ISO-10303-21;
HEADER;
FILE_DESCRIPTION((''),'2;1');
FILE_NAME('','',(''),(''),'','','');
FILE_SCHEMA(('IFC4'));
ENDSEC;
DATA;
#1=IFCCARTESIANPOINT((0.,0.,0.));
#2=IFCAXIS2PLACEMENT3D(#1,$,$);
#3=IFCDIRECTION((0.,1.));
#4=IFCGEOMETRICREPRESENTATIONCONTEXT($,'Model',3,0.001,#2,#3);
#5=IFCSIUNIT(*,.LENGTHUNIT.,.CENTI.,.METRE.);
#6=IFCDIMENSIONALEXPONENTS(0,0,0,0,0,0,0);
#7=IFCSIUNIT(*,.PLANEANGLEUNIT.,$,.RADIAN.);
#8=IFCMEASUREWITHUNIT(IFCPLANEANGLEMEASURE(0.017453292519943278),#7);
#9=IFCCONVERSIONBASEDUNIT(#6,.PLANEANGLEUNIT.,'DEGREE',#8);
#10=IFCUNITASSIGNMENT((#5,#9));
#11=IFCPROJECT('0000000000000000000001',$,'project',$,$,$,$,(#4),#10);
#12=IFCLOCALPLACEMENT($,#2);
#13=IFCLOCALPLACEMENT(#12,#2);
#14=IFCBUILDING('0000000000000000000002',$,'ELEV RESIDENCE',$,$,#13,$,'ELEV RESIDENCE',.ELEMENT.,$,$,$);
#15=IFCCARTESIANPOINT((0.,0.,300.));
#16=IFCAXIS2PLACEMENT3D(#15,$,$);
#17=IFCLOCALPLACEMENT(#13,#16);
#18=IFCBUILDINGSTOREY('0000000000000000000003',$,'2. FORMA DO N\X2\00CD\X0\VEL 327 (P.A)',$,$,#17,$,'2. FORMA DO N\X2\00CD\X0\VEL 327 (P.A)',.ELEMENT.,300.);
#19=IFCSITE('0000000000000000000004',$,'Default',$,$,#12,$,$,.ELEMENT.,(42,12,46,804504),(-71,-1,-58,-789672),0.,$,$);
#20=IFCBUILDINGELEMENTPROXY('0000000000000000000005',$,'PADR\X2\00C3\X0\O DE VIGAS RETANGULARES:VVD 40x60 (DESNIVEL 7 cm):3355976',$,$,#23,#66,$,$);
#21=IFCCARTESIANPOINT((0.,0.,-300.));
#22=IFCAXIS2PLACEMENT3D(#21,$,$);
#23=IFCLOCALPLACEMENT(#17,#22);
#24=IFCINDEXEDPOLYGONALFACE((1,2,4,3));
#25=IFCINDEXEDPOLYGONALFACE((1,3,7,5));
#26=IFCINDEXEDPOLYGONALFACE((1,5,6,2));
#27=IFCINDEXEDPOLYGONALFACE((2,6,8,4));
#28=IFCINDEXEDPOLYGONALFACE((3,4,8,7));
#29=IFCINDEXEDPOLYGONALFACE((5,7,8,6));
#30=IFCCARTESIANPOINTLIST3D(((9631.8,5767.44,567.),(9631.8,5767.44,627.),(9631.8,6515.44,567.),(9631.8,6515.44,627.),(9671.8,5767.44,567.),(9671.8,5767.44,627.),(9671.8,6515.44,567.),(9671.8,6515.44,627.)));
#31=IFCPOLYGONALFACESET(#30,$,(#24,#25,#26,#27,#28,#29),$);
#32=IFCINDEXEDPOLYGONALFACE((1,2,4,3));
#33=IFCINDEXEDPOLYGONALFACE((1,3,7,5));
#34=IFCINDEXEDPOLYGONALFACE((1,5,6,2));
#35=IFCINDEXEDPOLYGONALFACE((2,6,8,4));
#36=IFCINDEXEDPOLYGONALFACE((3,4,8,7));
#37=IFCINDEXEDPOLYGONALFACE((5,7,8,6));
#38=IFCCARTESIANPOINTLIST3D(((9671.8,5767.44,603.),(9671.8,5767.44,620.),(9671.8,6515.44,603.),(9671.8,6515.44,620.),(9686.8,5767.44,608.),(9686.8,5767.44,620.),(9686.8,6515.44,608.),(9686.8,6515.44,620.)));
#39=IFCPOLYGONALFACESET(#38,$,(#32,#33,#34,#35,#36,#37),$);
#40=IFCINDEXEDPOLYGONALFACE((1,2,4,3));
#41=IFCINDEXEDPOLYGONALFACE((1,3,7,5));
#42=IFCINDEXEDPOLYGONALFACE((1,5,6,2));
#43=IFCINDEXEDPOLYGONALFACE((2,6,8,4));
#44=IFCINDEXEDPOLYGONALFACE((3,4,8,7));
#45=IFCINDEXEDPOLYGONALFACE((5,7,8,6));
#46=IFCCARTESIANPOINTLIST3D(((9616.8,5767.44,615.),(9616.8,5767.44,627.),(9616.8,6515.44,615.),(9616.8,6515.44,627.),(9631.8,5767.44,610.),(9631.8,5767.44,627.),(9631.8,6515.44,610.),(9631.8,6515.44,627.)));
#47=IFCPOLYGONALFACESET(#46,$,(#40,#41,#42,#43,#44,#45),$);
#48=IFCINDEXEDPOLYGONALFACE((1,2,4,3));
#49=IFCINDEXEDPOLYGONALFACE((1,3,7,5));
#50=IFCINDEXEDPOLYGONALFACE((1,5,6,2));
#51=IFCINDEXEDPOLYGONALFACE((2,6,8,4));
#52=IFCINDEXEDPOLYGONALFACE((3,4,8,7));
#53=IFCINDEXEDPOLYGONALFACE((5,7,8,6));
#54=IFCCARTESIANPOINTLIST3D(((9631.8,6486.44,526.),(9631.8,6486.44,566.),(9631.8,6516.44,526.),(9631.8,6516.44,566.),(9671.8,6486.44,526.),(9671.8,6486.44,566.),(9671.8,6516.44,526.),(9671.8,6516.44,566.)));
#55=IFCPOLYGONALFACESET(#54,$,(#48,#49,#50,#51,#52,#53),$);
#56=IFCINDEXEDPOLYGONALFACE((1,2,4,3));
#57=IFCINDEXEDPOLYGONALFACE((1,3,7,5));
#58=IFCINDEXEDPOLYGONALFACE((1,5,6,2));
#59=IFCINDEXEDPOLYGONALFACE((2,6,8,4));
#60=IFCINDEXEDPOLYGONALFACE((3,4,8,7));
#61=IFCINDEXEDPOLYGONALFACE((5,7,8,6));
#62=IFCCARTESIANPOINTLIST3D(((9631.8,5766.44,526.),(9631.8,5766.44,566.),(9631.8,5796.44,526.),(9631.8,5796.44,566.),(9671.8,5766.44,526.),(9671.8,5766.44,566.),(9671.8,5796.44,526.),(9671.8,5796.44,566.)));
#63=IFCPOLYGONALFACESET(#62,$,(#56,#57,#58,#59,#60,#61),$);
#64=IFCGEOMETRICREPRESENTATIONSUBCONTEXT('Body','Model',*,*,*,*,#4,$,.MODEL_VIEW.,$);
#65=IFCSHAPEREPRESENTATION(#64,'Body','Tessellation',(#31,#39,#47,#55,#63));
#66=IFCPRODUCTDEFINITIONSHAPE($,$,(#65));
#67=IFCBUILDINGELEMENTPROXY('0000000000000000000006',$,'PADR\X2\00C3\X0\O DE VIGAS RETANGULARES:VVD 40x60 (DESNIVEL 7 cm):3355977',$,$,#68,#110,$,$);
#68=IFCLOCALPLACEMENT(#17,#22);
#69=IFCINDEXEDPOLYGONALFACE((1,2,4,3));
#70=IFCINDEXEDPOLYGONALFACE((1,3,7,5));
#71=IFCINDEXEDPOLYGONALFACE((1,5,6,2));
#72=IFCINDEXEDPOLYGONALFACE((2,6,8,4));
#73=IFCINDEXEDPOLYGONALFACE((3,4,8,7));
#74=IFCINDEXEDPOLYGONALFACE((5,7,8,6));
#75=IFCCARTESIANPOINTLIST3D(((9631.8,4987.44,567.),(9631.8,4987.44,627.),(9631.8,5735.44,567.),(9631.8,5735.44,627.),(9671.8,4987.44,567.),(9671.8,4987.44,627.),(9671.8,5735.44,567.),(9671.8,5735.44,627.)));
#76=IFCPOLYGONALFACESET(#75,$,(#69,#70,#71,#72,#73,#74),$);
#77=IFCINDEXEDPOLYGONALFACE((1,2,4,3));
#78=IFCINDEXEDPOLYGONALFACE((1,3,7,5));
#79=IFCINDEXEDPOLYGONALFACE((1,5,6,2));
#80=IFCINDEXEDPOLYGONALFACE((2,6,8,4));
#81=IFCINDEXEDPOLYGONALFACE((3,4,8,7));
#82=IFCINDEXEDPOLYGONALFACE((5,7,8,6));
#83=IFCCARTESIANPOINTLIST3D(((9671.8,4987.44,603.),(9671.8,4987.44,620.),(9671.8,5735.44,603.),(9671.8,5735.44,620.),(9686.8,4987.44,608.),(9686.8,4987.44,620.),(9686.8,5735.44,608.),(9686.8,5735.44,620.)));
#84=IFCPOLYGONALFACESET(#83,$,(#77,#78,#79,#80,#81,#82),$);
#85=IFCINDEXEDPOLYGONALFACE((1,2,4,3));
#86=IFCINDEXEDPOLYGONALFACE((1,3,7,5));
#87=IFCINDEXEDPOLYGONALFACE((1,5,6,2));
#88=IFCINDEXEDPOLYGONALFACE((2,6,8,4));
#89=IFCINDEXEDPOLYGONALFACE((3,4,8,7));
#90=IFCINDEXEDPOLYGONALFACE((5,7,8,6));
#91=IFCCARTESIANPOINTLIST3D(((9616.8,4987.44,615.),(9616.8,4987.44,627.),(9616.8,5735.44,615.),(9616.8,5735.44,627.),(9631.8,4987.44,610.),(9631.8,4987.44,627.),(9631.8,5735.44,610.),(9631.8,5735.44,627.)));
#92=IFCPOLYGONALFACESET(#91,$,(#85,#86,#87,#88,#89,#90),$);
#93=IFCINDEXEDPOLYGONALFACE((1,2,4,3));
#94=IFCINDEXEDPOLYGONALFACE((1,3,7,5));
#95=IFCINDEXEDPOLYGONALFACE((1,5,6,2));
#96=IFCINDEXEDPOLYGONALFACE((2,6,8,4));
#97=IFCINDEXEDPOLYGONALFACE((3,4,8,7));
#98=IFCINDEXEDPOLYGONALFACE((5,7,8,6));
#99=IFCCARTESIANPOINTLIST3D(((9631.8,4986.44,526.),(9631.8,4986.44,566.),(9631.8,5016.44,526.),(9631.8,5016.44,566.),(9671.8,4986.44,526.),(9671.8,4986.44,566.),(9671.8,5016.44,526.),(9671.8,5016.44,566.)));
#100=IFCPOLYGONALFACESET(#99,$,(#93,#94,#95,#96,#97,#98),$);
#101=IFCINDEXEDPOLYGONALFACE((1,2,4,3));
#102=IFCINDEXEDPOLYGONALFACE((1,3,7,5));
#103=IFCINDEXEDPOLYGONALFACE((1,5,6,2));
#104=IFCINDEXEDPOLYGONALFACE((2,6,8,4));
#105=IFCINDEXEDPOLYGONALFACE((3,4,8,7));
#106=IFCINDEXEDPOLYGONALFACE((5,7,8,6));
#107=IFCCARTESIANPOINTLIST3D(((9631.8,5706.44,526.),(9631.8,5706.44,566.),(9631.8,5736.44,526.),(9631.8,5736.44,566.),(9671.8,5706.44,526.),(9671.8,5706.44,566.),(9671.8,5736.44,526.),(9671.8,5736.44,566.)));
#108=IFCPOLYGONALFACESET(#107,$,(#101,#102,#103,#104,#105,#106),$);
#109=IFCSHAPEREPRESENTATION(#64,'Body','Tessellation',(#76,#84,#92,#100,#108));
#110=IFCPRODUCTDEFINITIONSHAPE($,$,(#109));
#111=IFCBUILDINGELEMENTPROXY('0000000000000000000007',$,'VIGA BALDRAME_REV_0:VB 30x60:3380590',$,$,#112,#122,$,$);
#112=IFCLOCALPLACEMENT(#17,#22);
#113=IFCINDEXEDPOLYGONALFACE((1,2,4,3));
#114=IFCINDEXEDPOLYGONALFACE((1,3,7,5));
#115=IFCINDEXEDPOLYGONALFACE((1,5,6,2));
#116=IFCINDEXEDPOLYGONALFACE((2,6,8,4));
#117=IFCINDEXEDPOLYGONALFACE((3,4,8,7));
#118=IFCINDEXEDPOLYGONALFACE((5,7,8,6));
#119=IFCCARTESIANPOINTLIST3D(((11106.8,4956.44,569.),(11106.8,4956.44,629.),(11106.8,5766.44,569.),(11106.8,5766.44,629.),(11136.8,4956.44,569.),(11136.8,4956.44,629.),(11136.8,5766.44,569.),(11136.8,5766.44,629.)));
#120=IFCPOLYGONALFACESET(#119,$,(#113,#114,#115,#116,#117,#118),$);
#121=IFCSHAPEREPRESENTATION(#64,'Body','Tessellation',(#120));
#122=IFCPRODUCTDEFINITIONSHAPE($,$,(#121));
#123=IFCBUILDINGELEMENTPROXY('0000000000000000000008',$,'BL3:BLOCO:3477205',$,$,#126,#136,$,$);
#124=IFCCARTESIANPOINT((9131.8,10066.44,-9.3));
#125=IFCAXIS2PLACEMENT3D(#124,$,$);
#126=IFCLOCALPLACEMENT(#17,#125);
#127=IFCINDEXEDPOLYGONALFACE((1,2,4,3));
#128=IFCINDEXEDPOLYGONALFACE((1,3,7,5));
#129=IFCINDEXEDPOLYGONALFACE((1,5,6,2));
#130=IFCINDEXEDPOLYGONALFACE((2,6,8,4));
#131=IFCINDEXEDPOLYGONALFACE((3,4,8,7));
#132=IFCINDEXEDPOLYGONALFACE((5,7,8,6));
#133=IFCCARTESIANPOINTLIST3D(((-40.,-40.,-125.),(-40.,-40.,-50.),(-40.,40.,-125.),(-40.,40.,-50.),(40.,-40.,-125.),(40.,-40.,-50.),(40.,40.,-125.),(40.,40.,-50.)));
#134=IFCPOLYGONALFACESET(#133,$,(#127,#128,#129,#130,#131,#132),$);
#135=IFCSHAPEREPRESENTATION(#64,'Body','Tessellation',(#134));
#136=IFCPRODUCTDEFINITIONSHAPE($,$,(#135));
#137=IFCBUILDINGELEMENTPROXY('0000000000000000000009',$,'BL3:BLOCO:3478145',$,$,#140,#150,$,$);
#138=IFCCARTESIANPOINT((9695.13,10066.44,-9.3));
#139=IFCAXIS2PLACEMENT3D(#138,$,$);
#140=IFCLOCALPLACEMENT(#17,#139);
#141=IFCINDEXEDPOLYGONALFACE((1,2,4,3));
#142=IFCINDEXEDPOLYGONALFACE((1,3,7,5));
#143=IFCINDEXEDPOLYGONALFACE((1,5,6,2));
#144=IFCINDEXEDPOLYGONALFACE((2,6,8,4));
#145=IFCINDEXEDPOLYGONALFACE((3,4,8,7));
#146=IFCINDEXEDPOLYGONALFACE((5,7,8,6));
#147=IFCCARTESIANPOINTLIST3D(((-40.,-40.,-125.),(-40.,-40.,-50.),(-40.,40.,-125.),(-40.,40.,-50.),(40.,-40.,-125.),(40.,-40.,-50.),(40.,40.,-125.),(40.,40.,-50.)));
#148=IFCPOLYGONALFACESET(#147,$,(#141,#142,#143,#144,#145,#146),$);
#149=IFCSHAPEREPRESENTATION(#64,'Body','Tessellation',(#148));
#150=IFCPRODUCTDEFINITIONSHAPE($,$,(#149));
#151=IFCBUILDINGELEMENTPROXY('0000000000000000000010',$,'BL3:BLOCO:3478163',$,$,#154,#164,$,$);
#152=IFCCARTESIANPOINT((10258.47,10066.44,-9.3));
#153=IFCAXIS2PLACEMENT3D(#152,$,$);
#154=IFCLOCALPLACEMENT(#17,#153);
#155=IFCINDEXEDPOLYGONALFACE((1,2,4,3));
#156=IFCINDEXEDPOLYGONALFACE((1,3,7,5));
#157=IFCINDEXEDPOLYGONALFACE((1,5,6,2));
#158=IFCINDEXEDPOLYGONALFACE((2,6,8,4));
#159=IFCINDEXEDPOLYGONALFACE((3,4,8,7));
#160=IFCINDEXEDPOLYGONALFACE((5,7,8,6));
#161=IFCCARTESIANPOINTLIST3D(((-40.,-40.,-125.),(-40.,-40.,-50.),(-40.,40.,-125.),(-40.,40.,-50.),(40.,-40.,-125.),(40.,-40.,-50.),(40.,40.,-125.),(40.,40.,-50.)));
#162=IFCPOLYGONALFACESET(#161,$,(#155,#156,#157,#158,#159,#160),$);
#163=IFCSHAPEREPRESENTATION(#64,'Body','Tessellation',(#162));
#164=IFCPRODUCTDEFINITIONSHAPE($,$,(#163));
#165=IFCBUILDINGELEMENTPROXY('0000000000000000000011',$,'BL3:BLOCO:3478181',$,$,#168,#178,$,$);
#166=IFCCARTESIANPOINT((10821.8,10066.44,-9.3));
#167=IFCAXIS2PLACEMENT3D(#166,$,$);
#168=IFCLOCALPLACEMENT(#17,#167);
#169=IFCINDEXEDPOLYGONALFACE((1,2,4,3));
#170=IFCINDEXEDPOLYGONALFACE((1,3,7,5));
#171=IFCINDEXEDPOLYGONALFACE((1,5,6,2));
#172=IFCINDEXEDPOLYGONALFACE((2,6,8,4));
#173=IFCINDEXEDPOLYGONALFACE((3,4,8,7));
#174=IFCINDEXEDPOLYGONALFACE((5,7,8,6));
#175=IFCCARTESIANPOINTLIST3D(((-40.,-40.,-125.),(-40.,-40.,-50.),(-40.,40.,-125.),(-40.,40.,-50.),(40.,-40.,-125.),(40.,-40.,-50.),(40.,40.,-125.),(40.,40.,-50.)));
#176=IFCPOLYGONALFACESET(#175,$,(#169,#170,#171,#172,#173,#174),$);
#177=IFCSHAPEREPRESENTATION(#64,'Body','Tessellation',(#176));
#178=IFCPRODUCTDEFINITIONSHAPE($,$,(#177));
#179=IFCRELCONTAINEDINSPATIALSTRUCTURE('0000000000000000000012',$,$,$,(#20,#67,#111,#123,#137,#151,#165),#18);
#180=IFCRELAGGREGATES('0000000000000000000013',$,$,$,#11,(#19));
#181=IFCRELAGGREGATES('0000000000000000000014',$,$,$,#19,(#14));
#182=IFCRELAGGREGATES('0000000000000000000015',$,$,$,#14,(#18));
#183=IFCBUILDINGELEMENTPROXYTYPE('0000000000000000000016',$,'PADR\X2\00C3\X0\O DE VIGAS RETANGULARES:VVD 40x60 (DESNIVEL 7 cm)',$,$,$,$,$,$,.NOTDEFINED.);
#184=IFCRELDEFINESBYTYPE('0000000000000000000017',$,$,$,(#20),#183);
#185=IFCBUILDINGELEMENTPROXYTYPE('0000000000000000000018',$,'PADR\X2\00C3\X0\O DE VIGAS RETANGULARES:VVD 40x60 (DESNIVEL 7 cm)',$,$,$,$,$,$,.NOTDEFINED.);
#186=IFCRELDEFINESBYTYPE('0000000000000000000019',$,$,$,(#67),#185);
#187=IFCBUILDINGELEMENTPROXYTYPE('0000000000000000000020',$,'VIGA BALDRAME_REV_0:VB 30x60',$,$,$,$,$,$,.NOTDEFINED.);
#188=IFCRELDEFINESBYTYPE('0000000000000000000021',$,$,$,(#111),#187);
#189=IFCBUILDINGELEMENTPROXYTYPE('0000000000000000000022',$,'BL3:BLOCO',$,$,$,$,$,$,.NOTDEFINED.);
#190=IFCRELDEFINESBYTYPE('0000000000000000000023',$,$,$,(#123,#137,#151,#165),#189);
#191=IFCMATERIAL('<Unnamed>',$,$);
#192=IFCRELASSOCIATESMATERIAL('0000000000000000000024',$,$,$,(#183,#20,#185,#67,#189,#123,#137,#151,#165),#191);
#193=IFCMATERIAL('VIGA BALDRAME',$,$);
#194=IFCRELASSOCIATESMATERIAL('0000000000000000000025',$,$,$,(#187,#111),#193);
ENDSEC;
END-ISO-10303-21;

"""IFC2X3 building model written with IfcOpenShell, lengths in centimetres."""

from ifc_helpers import new_model, entity, si_unit, converted_unit, direction, frame, frame_2d, origin, place, context, subcontext, project, spatial, polyline, rectangle, outline, extrude, source, transform, mapped, material, type_object, type_shapes, element, save


model = new_model("IFC2X3")

# Units and contexts
model_context = context("Model", 3, precision=0.001, world=origin(), true_north=direction((0.0, 1.0)))
body_context = subcontext(model_context, "Body", "Model", "MODEL_VIEW")
ifc_project = project(units=[si_unit("LENGTHUNIT", "METRE", prefix="CENTI"), converted_unit("PLANEANGLEUNIT", "DEGREE", entity("IfcPlaneAngleMeasure", 0.017453292519943278), si_unit("PLANEANGLEUNIT", "RADIAN"), dimensions=[0, 0, 0, 0, 0, 0, 0])], contexts=[model_context])

# Site, building, storey
site_placement = place(None, origin())
site = spatial("IfcSite", under=ifc_project, at=site_placement, Name="Default", CompositionType="ELEMENT", RefLatitude=(42, 12, 46, 804504), RefLongitude=(-71, -1, -58, -789672), RefElevation=0.0)
building_placement = place(site_placement, origin())
building = spatial("IfcBuilding", under=site, at=building_placement, Name="ELEV RESIDENCE", LongName="ELEV RESIDENCE", CompositionType="ELEMENT")
storey_placement = place(building_placement, frame((0.0, 0.0, 300.0)))
storey = spatial("IfcBuildingStorey", under=building, at=storey_placement, Name="2. FORMA DO NÍVEL 327 (P.A)", LongName="2. FORMA DO NÍVEL 327 (P.A)", CompositionType="ELEMENT", Elevation=300.0)

# Building element proxies
ifc_material_1 = material(Name="<Unnamed>")
building_element_proxy_type_1 = type_object("IfcBuildingElementProxyType", Name="PADRÃO DE VIGAS RETANGULARES:VVD 40x60 (DESNIVEL 7 cm)", PredefinedType="NOTDEFINED", material=ifc_material_1)
shared_shape_1 = source(origin(), body_context, "Body", "SweptSolid", [
    extrude(rectangle(XDim=40.0, YDim=748.0, at=frame_2d((0.0, 0.0), x_axis=(1.0, 0.0))), frame((9651.8, 6141.44, 567.0)), (0.0, 0.0, 1.0), 60.0),
    extrude(outline(polyline([(-7.25, -7.5), (4.75, -7.5), (9.75, 7.5), (-7.25, 7.5), (-7.25, -7.5)])), frame((9679.3, 5767.44, 612.75), z_axis=(0.0, 1.0, 0.0), x_axis=(0.0, 0.0, -1.0)), (0.0, 0.0, 1.0), 748.0),
    extrude(outline(polyline([(-7.5, -7.25), (7.5, -7.25), (7.5, 9.75), (-7.5, 4.75), (-7.5, -7.25)])), frame((9624.3, 5767.44, 619.75), z_axis=(0.0, 1.0, 0.0), x_axis=(1.0, 0.0, 0.0)), (0.0, 0.0, 1.0), 748.0),
    extrude(rectangle(XDim=30.0, YDim=40.0, at=frame_2d((0.0, 0.0), x_axis=(1.0, 0.0))), frame((9651.8, 6501.44, 526.0), z_axis=(0.0, 0.0, 1.0), x_axis=(0.0, 1.0, 0.0)), (0.0, 0.0, 1.0), 40.0),
    extrude(rectangle(XDim=30.0, YDim=40.0, at=frame_2d((0.0, 0.0), x_axis=(1.0, 0.0))), frame((9651.8, 5781.44, 526.0), z_axis=(0.0, 0.0, 1.0), x_axis=(0.0, 1.0, 0.0)), (0.0, 0.0, 1.0), 40.0),
])
type_shapes(building_element_proxy_type_1, [shared_shape_1])
proxy_1_placement = place(storey_placement, frame((0.0, 0.0, -300.0)))
element("IfcBuildingElementProxy", 1, at=proxy_1_placement, inside=storey, type_object=building_element_proxy_type_1, material=ifc_material_1, Name="PADRÃO DE VIGAS RETANGULARES:VVD 40x60 (DESNIVEL 7 cm):3355976", context=body_context, shape_type="MappedRepresentation", body=[
    mapped(shared_shape_1, transform((0.0, 0.0, 0.0), scale=1.0)),
])
building_element_proxy_type_2 = type_object("IfcBuildingElementProxyType", Name="PADRÃO DE VIGAS RETANGULARES:VVD 40x60 (DESNIVEL 7 cm)", PredefinedType="NOTDEFINED", material=ifc_material_1)
shared_shape_2 = source(origin(), body_context, "Body", "SweptSolid", [
    extrude(rectangle(XDim=748.0, YDim=40.0, at=frame_2d((0.0, 0.0), x_axis=(1.0, 0.0))), frame((9651.8, 5361.44, 567.0), z_axis=(0.0, 0.0, 1.0), x_axis=(0.0, -1.0, 0.0)), (0.0, 0.0, 1.0), 60.0),
    extrude(outline(polyline([(-7.25, -7.5), (4.75, -7.5), (9.75, 7.5), (-7.25, 7.5), (-7.25, -7.5)])), frame((9679.3, 4987.44, 612.75), z_axis=(0.0, 1.0, 0.0), x_axis=(0.0, 0.0, -1.0)), (0.0, 0.0, 1.0), 748.0),
    extrude(outline(polyline([(-7.5, -7.25), (7.5, -7.25), (7.5, 9.75), (-7.5, 4.75), (-7.5, -7.25)])), frame((9624.3, 4987.44, 619.75), z_axis=(0.0, 1.0, 0.0), x_axis=(1.0, 0.0, 0.0)), (0.0, 0.0, 1.0), 748.0),
    extrude(rectangle(XDim=40.0, YDim=30.0, at=frame_2d((0.0, 0.0), x_axis=(1.0, 0.0))), frame((9651.8, 5001.44, 526.0), z_axis=(0.0, 0.0, 1.0), x_axis=(-1.0, 0.0, 0.0)), (0.0, 0.0, 1.0), 40.0),
    extrude(rectangle(XDim=40.0, YDim=30.0, at=frame_2d((0.0, 0.0), x_axis=(1.0, 0.0))), frame((9651.8, 5721.44, 526.0), z_axis=(0.0, 0.0, 1.0), x_axis=(-1.0, 0.0, 0.0)), (0.0, 0.0, 1.0), 40.0),
])
type_shapes(building_element_proxy_type_2, [shared_shape_2])
proxy_2_placement = place(storey_placement, frame((0.0, 0.0, -300.0)))
element("IfcBuildingElementProxy", 2, at=proxy_2_placement, inside=storey, type_object=building_element_proxy_type_2, material=ifc_material_1, Name="PADRÃO DE VIGAS RETANGULARES:VVD 40x60 (DESNIVEL 7 cm):3355977", context=body_context, shape_type="MappedRepresentation", body=[
    mapped(shared_shape_2, transform((0.0, 0.0, 0.0), scale=1.0)),
])
ifc_material_2 = material(Name="VIGA BALDRAME")
building_element_proxy_type_3 = type_object("IfcBuildingElementProxyType", Name="VIGA BALDRAME_REV_0:VB 30x60", PredefinedType="NOTDEFINED", material=ifc_material_2)
shared_shape_3 = source(origin(), body_context, "Body", "SweptSolid", [
    extrude(rectangle(XDim=810.0, YDim=30.0, at=frame_2d((0.0, 0.0), x_axis=(1.0, 0.0))), frame((11121.8, 5361.44, 569.0), z_axis=(0.0, 0.0, 1.0), x_axis=(0.0, -1.0, 0.0)), (0.0, 0.0, 1.0), 60.0),
])
type_shapes(building_element_proxy_type_3, [shared_shape_3])
proxy_3_placement = place(storey_placement, frame((0.0, 0.0, -300.0)))
element("IfcBuildingElementProxy", 3, at=proxy_3_placement, inside=storey, type_object=building_element_proxy_type_3, material=ifc_material_2, Name="VIGA BALDRAME_REV_0:VB 30x60:3380590", context=body_context, shape_type="MappedRepresentation", body=[
    mapped(shared_shape_3, transform((0.0, 0.0, 0.0), scale=1.0)),
])
building_element_proxy_type_4 = type_object("IfcBuildingElementProxyType", Name="BL3:BLOCO", PredefinedType="NOTDEFINED", material=ifc_material_1)
shared_shape_4 = source(origin(), body_context, "Body", "SweptSolid", [
    extrude(rectangle(XDim=80.0, YDim=80.0, at=frame_2d((0.0, 0.0), x_axis=(1.0, 0.0))), frame((0.0, 0.0, -125.0), z_axis=(0.0, 0.0, 1.0), x_axis=(0.0, 1.0, 0.0)), (0.0, 0.0, 1.0), 75.0),
])
type_shapes(building_element_proxy_type_4, [shared_shape_4])
for number, where, name in (
    (4, (9131.8, 10066.44, -9.3), "BL3:BLOCO:3477205"),
    (5, (9695.13, 10066.44, -9.3), "BL3:BLOCO:3478145"),
    (6, (10258.47, 10066.44, -9.3), "BL3:BLOCO:3478163"),
    (7, (10821.8, 10066.44, -9.3), "BL3:BLOCO:3478181"),
):
    element("IfcBuildingElementProxy", number, at=place(storey_placement, frame(where)), inside=storey, type_object=building_element_proxy_type_4, material=ifc_material_1, Name=name, context=body_context, shape_type="MappedRepresentation", body=[
        mapped(shared_shape_4, transform((0.0, 0.0, 0.0), scale=1.0)),
    ])

save(model, "model.ifc")
